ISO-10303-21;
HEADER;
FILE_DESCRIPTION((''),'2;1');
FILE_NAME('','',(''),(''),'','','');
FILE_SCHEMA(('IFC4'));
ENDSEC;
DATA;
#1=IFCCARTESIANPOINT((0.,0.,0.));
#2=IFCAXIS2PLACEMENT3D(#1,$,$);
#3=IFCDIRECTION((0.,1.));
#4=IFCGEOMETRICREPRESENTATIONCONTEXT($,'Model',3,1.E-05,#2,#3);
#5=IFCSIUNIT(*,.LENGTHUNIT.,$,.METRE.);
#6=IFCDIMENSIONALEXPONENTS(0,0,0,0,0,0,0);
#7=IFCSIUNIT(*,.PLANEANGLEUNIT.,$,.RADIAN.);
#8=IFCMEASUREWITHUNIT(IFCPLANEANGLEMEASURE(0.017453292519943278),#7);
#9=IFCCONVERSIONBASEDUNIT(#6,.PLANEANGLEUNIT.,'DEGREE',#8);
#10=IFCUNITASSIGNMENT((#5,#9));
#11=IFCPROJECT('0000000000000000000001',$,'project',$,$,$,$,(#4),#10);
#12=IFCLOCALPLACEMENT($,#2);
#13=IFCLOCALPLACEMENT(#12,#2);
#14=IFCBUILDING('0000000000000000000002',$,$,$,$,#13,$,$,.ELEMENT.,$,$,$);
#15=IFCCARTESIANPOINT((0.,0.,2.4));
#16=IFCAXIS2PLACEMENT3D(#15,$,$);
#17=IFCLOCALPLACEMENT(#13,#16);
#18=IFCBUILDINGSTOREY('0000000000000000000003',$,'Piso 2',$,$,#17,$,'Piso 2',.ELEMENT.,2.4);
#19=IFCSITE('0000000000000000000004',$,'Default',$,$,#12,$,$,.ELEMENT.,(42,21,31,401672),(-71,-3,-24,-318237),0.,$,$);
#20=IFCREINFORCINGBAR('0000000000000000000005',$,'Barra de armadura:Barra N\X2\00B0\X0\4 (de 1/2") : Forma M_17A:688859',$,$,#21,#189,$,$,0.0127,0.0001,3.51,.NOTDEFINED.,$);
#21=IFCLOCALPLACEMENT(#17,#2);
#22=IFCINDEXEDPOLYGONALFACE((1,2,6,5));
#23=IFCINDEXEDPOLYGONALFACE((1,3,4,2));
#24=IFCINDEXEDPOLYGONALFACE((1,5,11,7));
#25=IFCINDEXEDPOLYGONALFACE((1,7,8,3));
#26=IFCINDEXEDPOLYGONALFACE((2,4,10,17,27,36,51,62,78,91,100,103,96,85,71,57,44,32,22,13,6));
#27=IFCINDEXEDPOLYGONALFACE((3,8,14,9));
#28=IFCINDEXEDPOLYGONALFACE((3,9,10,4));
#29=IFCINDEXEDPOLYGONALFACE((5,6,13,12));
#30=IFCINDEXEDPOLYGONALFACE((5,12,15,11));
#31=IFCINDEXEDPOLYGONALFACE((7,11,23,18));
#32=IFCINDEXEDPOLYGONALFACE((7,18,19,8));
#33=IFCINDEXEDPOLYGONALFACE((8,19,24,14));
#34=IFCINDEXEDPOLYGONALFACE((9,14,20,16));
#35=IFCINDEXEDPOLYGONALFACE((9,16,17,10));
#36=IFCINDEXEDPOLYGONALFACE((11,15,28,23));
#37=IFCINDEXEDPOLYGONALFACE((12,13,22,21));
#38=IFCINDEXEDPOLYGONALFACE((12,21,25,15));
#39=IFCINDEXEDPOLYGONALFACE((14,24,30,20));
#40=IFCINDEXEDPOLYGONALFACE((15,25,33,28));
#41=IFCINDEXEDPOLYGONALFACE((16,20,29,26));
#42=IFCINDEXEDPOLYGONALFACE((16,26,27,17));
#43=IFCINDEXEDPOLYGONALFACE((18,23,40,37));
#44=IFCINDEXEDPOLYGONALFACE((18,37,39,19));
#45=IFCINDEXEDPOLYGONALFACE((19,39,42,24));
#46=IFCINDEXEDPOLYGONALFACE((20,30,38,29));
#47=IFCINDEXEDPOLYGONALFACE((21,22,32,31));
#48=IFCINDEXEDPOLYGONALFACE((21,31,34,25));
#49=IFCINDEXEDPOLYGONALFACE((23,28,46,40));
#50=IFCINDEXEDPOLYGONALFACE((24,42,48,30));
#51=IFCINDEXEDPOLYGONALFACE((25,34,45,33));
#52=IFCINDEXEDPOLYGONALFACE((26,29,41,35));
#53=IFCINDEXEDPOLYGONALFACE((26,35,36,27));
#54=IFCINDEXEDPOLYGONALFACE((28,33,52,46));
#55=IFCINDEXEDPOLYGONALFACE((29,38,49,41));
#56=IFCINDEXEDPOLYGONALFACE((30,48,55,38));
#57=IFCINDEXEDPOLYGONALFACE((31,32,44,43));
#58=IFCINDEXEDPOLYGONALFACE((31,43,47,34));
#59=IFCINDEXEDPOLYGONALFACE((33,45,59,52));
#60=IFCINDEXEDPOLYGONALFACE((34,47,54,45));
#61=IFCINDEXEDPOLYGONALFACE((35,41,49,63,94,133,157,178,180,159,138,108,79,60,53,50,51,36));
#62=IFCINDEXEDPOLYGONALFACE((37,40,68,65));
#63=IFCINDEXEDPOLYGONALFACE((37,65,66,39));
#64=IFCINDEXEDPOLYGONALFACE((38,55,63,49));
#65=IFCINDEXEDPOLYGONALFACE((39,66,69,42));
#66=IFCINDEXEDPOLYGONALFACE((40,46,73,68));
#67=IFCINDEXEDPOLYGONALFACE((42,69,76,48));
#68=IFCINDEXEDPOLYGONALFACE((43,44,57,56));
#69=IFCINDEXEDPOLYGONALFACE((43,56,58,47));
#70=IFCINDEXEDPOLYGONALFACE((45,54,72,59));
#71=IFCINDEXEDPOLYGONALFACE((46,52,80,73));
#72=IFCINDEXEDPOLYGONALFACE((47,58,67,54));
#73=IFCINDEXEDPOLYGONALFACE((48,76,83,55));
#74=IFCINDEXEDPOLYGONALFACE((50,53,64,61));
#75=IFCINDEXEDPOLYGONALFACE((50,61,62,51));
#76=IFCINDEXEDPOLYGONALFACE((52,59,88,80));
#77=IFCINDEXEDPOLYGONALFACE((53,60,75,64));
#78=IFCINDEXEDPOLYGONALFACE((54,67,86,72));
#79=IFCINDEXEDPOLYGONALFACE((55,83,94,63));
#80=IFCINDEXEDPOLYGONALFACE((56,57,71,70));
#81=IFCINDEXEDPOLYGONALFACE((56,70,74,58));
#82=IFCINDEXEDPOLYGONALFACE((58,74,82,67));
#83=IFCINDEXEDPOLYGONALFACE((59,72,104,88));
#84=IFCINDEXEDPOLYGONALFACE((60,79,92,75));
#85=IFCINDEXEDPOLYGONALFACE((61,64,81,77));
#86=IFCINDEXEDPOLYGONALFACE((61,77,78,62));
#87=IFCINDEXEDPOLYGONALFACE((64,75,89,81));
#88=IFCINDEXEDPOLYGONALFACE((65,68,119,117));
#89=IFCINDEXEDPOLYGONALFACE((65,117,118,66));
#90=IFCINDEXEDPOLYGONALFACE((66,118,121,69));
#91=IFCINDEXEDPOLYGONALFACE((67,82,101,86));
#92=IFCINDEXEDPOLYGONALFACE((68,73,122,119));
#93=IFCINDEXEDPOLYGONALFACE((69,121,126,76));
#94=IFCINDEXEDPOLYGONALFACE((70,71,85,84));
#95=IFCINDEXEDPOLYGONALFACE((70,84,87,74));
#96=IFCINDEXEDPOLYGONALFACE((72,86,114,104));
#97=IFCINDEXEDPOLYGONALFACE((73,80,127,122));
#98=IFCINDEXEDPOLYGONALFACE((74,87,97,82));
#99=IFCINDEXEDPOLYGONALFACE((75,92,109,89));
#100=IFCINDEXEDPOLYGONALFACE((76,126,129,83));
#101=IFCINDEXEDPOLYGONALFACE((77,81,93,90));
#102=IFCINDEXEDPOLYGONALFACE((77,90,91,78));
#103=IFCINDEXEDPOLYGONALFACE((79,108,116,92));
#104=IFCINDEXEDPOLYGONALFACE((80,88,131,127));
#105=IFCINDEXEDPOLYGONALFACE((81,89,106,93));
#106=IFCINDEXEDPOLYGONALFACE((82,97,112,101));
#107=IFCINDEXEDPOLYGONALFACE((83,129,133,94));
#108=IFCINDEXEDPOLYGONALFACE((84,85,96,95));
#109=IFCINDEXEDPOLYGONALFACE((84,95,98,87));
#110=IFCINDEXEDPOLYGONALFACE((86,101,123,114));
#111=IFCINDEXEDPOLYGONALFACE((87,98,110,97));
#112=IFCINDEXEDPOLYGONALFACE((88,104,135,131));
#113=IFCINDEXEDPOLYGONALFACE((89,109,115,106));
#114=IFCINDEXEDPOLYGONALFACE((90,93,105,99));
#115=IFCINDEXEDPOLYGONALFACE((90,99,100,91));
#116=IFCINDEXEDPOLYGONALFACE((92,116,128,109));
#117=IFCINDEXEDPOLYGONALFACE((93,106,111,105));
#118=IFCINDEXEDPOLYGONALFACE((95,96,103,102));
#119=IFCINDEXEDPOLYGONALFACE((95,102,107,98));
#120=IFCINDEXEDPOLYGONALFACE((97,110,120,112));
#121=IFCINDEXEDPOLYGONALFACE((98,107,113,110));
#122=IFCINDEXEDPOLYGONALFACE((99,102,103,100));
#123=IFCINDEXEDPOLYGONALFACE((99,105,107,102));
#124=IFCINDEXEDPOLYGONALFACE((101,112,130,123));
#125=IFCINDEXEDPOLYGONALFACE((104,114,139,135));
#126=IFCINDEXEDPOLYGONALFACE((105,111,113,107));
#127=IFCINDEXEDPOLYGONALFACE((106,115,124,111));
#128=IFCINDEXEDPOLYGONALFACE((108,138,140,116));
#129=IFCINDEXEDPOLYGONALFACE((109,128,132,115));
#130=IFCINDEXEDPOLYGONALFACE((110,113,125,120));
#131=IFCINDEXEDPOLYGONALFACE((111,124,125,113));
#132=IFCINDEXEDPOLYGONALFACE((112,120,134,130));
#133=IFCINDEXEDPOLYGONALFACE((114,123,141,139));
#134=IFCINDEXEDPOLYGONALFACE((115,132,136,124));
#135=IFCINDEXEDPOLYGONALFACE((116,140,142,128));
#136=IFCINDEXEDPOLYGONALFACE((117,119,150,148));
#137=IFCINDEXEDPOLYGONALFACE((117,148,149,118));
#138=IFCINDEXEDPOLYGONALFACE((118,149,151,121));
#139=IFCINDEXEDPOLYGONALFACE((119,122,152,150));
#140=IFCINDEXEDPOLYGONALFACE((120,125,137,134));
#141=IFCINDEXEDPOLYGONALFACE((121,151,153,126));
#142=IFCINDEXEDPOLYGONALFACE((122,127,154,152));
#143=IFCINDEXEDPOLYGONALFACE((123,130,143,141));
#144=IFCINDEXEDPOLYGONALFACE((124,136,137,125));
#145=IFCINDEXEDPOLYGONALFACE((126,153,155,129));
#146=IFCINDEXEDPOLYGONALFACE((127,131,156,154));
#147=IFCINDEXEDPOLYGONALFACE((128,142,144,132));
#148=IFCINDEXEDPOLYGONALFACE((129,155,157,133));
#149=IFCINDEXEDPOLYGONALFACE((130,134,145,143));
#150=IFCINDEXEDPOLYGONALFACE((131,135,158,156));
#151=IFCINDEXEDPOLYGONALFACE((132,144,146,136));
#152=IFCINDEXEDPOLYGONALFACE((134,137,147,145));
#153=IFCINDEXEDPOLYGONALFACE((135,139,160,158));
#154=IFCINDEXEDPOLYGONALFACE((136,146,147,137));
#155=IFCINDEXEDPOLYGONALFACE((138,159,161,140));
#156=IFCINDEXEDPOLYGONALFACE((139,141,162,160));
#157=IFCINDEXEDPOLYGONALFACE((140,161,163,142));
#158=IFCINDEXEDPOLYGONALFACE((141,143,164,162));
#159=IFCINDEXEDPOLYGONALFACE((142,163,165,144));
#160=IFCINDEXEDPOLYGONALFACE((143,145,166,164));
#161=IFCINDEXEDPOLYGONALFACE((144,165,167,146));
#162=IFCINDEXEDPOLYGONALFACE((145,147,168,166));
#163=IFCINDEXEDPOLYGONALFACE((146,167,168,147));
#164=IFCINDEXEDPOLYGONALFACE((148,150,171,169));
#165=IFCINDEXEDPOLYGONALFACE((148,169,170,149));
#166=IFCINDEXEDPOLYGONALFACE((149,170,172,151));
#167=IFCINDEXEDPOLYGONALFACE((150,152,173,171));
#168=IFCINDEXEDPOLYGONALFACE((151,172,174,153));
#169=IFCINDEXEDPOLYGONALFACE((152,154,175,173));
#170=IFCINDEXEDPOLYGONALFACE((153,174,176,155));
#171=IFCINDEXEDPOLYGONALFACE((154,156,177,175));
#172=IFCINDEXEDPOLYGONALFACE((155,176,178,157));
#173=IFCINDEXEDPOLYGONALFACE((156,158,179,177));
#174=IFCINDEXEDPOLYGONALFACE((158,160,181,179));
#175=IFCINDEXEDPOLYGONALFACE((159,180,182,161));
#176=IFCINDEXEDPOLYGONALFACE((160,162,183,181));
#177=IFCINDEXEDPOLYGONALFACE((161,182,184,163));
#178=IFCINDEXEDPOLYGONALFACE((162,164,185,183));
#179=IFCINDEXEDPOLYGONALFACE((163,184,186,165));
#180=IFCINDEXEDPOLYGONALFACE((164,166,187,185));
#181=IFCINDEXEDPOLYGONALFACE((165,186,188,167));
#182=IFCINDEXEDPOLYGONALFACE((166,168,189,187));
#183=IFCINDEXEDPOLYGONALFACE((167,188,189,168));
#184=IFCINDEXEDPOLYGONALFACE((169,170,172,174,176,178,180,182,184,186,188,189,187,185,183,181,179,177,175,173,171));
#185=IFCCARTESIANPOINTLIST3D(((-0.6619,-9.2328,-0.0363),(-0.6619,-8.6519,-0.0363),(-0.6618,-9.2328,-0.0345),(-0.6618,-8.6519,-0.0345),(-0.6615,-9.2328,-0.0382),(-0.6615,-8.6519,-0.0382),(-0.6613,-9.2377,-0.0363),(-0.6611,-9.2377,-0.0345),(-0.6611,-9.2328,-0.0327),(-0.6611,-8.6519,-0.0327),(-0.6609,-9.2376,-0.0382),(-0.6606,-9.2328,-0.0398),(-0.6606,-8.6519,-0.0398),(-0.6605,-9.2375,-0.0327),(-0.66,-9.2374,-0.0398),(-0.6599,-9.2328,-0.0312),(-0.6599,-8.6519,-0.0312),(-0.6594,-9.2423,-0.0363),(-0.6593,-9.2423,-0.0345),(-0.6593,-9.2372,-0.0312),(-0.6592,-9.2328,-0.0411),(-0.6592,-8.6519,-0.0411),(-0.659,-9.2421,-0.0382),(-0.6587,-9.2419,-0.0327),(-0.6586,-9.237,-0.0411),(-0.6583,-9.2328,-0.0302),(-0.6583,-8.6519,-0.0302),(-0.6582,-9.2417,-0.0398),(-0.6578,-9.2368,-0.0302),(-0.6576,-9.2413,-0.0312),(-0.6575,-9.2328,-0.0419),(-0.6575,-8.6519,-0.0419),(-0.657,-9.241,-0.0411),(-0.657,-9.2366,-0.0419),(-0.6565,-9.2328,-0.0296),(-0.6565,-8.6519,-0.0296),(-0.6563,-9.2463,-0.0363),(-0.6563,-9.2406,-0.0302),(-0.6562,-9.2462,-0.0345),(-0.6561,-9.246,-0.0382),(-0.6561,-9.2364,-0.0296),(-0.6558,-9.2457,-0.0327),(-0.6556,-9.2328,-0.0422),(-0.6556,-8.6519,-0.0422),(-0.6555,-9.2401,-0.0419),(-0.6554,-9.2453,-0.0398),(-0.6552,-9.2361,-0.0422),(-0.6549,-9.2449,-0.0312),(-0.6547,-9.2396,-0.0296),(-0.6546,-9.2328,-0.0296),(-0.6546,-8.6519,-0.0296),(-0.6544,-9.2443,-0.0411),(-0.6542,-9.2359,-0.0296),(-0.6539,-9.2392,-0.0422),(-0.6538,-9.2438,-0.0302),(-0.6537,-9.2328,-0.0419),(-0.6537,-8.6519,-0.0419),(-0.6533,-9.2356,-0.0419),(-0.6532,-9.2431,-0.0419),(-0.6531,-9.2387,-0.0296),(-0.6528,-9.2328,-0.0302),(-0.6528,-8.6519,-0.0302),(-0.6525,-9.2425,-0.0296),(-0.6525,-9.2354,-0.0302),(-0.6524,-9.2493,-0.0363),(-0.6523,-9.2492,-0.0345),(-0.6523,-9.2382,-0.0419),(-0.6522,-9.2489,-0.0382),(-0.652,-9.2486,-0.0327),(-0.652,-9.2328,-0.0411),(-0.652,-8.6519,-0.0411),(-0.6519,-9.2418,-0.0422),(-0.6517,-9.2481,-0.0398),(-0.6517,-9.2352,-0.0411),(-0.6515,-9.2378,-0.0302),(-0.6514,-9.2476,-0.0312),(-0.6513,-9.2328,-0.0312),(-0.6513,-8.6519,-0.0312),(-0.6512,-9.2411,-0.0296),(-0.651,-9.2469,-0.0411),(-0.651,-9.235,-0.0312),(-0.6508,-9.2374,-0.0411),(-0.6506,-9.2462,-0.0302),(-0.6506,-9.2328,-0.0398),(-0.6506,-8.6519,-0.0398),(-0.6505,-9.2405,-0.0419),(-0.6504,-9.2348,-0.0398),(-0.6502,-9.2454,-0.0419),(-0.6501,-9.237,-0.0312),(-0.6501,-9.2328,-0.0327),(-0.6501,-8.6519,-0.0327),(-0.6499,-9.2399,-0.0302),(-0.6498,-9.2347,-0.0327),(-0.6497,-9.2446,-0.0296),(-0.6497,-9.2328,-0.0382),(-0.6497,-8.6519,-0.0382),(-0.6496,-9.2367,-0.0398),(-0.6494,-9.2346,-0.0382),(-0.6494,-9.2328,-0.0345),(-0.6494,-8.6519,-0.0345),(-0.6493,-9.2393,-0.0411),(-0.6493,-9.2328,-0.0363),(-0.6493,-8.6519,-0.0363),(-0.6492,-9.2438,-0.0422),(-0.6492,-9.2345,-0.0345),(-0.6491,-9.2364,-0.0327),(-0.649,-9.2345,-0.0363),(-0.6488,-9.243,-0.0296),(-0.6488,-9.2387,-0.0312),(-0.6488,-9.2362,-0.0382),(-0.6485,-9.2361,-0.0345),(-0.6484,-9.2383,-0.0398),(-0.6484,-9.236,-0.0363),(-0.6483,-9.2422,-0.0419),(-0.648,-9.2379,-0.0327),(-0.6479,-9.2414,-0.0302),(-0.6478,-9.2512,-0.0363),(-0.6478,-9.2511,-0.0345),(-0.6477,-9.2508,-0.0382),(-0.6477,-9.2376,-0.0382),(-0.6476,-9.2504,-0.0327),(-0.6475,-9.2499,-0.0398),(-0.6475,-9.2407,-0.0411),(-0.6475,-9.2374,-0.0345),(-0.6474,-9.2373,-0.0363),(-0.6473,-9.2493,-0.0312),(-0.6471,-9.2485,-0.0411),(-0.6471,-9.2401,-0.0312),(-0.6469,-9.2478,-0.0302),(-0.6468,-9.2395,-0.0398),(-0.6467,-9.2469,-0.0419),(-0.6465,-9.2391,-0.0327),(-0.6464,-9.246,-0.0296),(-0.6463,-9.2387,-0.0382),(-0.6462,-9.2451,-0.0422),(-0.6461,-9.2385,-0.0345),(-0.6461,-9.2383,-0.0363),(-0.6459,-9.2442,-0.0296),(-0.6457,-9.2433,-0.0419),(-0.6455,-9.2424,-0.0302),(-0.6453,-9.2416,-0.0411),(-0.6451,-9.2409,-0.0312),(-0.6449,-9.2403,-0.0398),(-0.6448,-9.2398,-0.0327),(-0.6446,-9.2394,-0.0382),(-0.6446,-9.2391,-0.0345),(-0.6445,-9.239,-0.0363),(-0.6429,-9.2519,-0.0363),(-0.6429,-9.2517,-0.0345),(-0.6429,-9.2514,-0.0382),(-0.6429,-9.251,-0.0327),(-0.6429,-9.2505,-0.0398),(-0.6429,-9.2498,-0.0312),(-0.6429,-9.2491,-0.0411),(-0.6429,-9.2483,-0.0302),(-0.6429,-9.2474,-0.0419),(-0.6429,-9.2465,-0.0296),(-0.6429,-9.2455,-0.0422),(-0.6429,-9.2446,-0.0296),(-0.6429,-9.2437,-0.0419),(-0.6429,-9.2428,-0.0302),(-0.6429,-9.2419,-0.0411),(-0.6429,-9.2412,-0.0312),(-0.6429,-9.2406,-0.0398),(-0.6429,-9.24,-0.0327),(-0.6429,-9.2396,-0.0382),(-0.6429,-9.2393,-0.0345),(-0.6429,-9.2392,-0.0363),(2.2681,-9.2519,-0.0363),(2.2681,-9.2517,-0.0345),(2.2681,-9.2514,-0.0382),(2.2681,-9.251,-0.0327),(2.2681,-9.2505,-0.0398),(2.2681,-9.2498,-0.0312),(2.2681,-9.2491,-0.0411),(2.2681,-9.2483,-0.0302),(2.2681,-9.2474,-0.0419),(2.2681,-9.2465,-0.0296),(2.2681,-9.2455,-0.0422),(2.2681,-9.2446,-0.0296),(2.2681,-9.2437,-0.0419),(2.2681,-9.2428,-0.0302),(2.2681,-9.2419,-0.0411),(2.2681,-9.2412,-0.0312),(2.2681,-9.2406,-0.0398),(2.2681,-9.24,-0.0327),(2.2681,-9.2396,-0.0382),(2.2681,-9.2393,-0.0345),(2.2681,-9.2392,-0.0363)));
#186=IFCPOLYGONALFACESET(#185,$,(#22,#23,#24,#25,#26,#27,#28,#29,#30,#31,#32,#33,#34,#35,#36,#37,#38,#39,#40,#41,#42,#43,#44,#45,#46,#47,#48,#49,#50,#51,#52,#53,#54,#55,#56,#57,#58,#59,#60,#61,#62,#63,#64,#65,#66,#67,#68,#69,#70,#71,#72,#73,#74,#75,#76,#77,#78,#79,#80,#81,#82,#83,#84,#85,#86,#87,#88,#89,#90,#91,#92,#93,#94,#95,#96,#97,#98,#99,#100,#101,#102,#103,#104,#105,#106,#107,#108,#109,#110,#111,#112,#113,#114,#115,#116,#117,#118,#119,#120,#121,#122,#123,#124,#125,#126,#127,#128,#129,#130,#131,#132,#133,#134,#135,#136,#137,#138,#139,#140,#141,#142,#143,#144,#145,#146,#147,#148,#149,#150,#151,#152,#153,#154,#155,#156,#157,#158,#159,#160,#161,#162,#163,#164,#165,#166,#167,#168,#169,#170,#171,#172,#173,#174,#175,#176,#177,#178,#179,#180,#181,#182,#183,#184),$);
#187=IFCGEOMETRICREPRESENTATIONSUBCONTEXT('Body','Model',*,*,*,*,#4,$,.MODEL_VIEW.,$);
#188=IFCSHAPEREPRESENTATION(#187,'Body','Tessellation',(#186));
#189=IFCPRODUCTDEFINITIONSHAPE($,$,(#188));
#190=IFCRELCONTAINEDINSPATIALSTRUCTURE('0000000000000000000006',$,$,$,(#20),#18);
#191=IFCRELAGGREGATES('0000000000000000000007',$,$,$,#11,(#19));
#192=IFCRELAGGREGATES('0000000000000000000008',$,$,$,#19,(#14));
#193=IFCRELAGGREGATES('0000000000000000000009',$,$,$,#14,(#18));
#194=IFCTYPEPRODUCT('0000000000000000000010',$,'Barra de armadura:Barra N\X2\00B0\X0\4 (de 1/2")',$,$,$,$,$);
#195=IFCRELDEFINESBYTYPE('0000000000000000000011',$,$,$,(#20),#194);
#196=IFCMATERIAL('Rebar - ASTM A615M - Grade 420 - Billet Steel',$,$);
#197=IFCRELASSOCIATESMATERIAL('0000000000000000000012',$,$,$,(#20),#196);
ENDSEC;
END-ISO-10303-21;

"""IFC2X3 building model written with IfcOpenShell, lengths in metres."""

from ifc_helpers import new_model, entity, si_unit, converted_unit, direction, frame, origin, place, context, subcontext, project, spatial, material, type_object, element, save


model = new_model("IFC2X3")

# Units and contexts
model_context = context("Model", 3, precision=1e-05, world=origin(), true_north=direction((0.0, 1.0)))
body_context = subcontext(model_context, "Body", "Model", "MODEL_VIEW")
ifc_project = project(units=[si_unit("LENGTHUNIT", "METRE"), converted_unit("PLANEANGLEUNIT", "DEGREE", entity("IfcPlaneAngleMeasure", 0.017453292519943278), si_unit("PLANEANGLEUNIT", "RADIAN"), dimensions=[0, 0, 0, 0, 0, 0, 0])], contexts=[model_context])

# Site, building, storey
site_placement = place(None, origin())
site = spatial("IfcSite", under=ifc_project, at=site_placement, Name="Default", CompositionType="ELEMENT", RefLatitude=(42, 21, 31, 401672), RefLongitude=(-71, -3, -24, -318237), RefElevation=0.0)
building_placement = place(site_placement, origin())
building = spatial("IfcBuilding", under=site, at=building_placement, CompositionType="ELEMENT")
storey_placement = place(building_placement, frame((0.0, 0.0, 2.4)))
storey = spatial("IfcBuildingStorey", under=building, at=storey_placement, Name="Piso 2", LongName="Piso 2", CompositionType="ELEMENT", Elevation=2.4)

# Reinforcing bar
ifc_material_1 = material(Name="Rebar - ASTM A615M - Grade 420 - Billet Steel")
type_product_1 = type_object("IfcTypeProduct", Name="Barra de armadura:Barra N°4 (de 1/2\")")
reinforcing_bar_1_placement = place(storey_placement, origin())
element("IfcReinforcingBar", 1, at=reinforcing_bar_1_placement, inside=storey, type_object=type_product_1, material=ifc_material_1, Name="Barra de armadura:Barra N°4 (de 1/2\") : Forma M_17A:688859", BarLength=3.51, BarRole="NOTDEFINED", CrossSectionArea=0.0001, NominalDiameter=0.0127, context=body_context, shape_type="AdvancedSweptSolid", body=[
    entity("IfcSweptDiskSolid", entity("IfcCompositeCurve", [entity("IfcCompositeCurveSegment", "CONTINUOUS", True, entity("IfcPolyline", [entity("IfcCartesianPoint", [2.2681, -9.2455, -0.0359]), entity("IfcCartesianPoint", [-0.6429, -9.2455, -0.0359])])), entity("IfcCompositeCurveSegment", "CONTINUOUS", True, entity("IfcTrimmedCurve", entity("IfcCircle", entity("IfcAxis2Placement3D", entity("IfcCartesianPoint", [-0.6429, -9.2328, -0.0359]), entity("IfcDirection", [0.0, 0.0, -1.0]), entity("IfcDirection", [-1.0, 0.0, 0.0])), 0.0127), [entity("IfcParameterValue", 270.0)], [entity("IfcParameterValue", 360.0)], True, "PARAMETER")), entity("IfcCompositeCurveSegment", "CONTINUOUS", True, entity("IfcPolyline", [entity("IfcCartesianPoint", [-0.6556, -9.2328, -0.0359]), entity("IfcCartesianPoint", [-0.6556, -8.6519, -0.0359])]))], False), 0.0063, None, 0.0, 92.0),
])

save(model, "model.ifc")
